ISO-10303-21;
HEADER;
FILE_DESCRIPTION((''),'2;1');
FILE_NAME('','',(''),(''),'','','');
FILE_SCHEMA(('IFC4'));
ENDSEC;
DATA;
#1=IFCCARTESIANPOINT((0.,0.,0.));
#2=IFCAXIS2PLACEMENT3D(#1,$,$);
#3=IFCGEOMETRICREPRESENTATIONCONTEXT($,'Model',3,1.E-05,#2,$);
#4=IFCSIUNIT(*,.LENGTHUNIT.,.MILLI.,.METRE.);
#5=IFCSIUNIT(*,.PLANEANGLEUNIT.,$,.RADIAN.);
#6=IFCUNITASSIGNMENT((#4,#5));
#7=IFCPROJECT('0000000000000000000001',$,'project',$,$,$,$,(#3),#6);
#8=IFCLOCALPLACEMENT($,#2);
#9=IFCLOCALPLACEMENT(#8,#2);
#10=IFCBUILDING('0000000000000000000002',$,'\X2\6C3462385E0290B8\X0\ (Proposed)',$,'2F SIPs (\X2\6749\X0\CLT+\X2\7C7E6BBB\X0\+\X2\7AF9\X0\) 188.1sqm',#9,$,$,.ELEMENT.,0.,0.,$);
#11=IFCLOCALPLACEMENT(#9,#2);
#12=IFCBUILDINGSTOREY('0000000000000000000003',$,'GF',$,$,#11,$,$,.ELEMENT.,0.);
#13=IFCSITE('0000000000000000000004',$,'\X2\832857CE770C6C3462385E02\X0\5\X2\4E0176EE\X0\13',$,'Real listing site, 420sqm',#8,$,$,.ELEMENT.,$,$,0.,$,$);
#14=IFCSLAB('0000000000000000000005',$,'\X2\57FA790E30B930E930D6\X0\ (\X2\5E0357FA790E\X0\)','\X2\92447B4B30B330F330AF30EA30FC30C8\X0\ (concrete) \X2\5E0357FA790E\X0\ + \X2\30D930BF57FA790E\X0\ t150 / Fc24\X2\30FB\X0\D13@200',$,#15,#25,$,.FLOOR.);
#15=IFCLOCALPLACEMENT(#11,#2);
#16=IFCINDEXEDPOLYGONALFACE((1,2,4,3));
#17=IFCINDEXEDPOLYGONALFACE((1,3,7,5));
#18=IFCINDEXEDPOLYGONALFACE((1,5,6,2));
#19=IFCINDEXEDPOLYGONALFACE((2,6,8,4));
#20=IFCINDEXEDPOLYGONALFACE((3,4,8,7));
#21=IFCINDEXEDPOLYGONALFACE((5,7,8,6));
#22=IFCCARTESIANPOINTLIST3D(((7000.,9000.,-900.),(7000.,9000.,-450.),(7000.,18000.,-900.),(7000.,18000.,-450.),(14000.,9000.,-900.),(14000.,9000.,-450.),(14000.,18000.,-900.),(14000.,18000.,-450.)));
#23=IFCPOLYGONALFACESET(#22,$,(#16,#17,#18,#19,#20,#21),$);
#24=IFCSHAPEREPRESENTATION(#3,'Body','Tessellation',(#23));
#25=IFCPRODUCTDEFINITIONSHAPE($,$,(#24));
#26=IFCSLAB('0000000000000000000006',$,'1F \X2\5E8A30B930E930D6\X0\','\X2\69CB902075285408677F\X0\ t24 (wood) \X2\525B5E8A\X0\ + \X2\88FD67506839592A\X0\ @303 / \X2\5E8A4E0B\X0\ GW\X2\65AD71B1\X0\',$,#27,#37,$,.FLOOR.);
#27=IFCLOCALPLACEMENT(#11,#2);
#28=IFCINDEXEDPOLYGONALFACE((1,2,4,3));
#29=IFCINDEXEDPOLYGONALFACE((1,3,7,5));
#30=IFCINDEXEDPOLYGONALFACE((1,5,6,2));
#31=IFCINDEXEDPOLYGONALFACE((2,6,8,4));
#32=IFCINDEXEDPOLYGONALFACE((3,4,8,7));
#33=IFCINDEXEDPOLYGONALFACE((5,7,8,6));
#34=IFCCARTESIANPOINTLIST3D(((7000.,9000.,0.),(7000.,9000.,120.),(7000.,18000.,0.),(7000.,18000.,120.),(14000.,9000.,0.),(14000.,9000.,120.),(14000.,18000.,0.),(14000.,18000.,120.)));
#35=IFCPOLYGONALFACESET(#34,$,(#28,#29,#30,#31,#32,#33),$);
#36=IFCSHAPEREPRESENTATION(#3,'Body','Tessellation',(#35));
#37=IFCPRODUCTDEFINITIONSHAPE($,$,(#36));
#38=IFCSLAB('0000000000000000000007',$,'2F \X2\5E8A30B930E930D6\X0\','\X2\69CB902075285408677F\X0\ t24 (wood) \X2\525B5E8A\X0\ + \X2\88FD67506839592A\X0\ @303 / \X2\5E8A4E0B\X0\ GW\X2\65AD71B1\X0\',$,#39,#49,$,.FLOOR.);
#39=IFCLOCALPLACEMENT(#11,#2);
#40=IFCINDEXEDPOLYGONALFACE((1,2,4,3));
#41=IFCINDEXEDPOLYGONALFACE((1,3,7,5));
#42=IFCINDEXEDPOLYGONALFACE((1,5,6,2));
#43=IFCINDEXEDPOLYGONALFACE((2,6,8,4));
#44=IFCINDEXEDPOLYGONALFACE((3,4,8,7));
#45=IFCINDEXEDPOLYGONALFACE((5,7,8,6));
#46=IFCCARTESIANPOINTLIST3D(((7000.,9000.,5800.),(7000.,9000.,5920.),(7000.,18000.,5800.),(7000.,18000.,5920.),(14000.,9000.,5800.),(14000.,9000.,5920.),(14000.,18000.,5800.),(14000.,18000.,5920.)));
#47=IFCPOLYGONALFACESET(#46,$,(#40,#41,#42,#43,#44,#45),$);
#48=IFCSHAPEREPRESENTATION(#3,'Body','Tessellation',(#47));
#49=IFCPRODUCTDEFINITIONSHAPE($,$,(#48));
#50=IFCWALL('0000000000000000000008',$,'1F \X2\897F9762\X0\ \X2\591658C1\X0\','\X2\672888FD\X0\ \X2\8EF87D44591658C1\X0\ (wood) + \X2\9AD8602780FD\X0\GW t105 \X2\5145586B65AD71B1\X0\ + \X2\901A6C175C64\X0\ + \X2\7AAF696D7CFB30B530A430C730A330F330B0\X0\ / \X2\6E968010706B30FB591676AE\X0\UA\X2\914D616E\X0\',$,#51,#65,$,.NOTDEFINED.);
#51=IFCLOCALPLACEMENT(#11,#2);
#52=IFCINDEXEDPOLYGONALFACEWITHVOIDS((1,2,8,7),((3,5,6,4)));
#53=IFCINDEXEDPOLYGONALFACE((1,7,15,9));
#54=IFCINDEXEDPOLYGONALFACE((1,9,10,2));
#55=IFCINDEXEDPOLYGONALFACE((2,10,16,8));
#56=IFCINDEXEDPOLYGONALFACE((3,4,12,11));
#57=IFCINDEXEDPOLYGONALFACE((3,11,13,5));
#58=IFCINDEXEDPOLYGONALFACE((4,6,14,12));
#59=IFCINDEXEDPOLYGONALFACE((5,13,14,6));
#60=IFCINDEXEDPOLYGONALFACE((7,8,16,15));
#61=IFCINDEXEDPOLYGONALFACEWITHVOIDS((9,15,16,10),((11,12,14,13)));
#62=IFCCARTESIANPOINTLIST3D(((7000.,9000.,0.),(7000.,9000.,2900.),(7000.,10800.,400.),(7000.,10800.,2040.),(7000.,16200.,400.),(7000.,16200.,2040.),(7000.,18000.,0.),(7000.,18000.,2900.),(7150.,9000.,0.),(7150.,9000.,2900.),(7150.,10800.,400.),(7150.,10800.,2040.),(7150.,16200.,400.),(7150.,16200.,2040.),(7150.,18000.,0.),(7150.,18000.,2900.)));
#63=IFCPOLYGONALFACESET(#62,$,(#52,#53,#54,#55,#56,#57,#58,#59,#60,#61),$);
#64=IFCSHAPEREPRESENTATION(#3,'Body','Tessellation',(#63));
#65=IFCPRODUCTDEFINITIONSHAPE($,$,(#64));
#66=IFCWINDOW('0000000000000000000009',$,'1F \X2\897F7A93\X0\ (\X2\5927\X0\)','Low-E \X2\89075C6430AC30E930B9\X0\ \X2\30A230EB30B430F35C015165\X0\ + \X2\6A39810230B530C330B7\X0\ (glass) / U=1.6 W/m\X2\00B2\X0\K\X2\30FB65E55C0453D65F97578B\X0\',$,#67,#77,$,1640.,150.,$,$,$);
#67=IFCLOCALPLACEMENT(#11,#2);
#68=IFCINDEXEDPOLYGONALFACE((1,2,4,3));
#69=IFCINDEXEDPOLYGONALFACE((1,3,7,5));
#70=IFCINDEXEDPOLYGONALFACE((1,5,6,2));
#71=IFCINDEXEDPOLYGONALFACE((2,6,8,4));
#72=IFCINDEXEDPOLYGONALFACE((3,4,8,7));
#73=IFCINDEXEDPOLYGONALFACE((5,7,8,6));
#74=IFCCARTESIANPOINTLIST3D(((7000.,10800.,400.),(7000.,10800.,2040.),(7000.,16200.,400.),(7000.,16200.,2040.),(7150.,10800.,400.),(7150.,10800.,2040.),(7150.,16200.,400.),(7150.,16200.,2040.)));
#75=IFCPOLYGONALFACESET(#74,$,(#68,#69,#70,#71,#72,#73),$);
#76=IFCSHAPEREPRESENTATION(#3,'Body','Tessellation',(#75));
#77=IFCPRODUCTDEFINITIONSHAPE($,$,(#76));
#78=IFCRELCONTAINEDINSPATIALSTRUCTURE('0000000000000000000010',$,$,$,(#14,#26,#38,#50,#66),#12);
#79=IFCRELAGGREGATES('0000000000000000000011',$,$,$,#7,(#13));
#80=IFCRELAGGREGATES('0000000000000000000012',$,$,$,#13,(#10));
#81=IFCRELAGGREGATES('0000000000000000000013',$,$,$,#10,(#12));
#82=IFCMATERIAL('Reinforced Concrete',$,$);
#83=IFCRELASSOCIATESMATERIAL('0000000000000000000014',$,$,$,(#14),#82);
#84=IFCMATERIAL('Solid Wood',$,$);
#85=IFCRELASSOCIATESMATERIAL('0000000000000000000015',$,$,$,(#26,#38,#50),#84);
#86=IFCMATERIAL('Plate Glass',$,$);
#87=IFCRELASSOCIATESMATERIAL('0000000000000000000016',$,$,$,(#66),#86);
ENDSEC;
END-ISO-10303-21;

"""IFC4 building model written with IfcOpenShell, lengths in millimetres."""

from ifc_helpers import new_model, si_unit, frame, frame_2d, origin, place, context, project, spatial, rectangle, extrude, material, element, fill, save


model = new_model("IFC4")

# Units and contexts
model_context = context("Model", 3, precision=1e-05, world=origin())
ifc_project = project(units=[si_unit("LENGTHUNIT", "METRE", prefix="MILLI"), si_unit("PLANEANGLEUNIT", "RADIAN")], contexts=[model_context])

# Site, building, storey
site_placement = place(None, origin())
site = spatial("IfcSite", under=ifc_project, at=site_placement, Name="茨城県水戸市5丁目13", ObjectType="Real listing site, 420sqm", CompositionType="ELEMENT", RefElevation=0.0)
building_placement = place(site_placement, origin())
building = spatial("IfcBuilding", under=site, at=building_placement, Name="水戸市邸 (Proposed)", ObjectType="2F SIPs (杉CLT+籾殻+竹) 188.1sqm", CompositionType="ELEMENT", ElevationOfRefHeight=0.0, ElevationOfTerrain=0.0)
storey_placement = place(building_placement, origin())
storey = spatial("IfcBuildingStorey", under=building, at=storey_placement, Name="GF", CompositionType="ELEMENT", Elevation=0.0)

# Slabs
ifc_material_1 = material(Name="Reinforced Concrete")
slab_1_placement = place(storey_placement, frame((3500.0, 4500.0, -450.0)))
element("IfcSlab", 1, at=slab_1_placement, inside=storey, material=ifc_material_1, Name="基礎スラブ (布基礎)", Description="鉄筋コンクリート (concrete) 布基礎 + ベタ基礎 t150 / Fc24・D13@200", PredefinedType="FLOOR", context=model_context, shape_type="SweptSolid", body=[
    extrude(rectangle(XDim=7000.0, YDim=9000.0, at=frame_2d((3500.0, 4500.0))), frame((3500.0, 4500.0, -450.0)), (0.0, 0.0, 1.0), 450.0),
])
ifc_material_2 = material(Name="Solid Wood")
slab_2_placement = place(storey_placement, frame((3500.0, 4500.0, 0.0)))
element("IfcSlab", 2, at=slab_2_placement, inside=storey, material=ifc_material_2, Name="1F 床スラブ", Description="構造用合板 t24 (wood) 剛床 + 製材根太 @303 / 床下 GW断熱", PredefinedType="FLOOR", context=model_context, shape_type="SweptSolid", body=[
    extrude(rectangle(XDim=7000.0, YDim=9000.0, at=frame_2d((3500.0, 4500.0))), frame((3500.0, 4500.0, 0.0)), (0.0, 0.0, 1.0), 120.0),
])
slab_3_placement = place(storey_placement, frame((3500.0, 4500.0, 2900.0)))
element("IfcSlab", 3, at=slab_3_placement, inside=storey, material=ifc_material_2, Name="2F 床スラブ", Description="構造用合板 t24 (wood) 剛床 + 製材根太 @303 / 床下 GW断熱", PredefinedType="FLOOR", context=model_context, shape_type="SweptSolid", body=[
    extrude(rectangle(XDim=7000.0, YDim=9000.0, at=frame_2d((3500.0, 4500.0))), frame((3500.0, 4500.0, 2900.0)), (0.0, 0.0, 1.0), 120.0),
])

# Shared definitions
ifc_material_3 = material(Name="Plate Glass")

# Wall, opening, window
wall_1_placement = place(storey_placement, frame((3500.0, 4500.0, 0.0)))
wall_1 = element("IfcWall", 4, at=wall_1_placement, inside=storey, material=ifc_material_2, Name="1F 西面 外壁", Description="木製 軸組外壁 (wood) + 高性能GW t105 充填断熱 + 通気層 + 窯業系サイディング / 準耐火・外皮UA配慮", PredefinedType="NOTDEFINED", context=model_context, shape_type="SweptSolid", body=[
    extrude(rectangle(XDim=150.0, YDim=9000.0, at=frame_2d((75.0, 4500.0))), frame((3500.0, 4500.0, 0.0)), (0.0, 0.0, 1.0), 2900.0),
])
opening_1_placement = place(storey_placement, frame((3500.0, 5400.0, 200.0)))
opening_1 = element("IfcOpeningElement", 5, at=opening_1_placement, cuts=wall_1, PredefinedType="NOTDEFINED", context=model_context, shape_type="SweptSolid", body=[
    extrude(rectangle(XDim=150.0, YDim=5400.0, at=frame_2d((75.0, 2700.0))), frame((3500.0, 5400.0, 200.0)), (0.0, 0.0, 1.0), 1640.0),
])
window_1_placement = place(storey_placement, frame((3500.0, 5400.0, 200.0)))
window_1 = element("IfcWindow", 6, at=window_1_placement, inside=storey, material=ifc_material_3, Name="1F 西窓 (大)", Description="Low-E 複層ガラス アルゴン封入 + 樹脂サッシ (glass) / U=1.6 W/m²K・日射取得型", OverallHeight=1640.0, OverallWidth=150.0, context=model_context, shape_type="SweptSolid", body=[
    extrude(rectangle(XDim=150.0, YDim=5400.0, at=frame_2d((75.0, 2700.0))), frame((3500.0, 5400.0, 200.0)), (0.0, 0.0, 1.0), 1640.0),
])
fill(opening_1, window_1)

save(model, "model.ifc")
